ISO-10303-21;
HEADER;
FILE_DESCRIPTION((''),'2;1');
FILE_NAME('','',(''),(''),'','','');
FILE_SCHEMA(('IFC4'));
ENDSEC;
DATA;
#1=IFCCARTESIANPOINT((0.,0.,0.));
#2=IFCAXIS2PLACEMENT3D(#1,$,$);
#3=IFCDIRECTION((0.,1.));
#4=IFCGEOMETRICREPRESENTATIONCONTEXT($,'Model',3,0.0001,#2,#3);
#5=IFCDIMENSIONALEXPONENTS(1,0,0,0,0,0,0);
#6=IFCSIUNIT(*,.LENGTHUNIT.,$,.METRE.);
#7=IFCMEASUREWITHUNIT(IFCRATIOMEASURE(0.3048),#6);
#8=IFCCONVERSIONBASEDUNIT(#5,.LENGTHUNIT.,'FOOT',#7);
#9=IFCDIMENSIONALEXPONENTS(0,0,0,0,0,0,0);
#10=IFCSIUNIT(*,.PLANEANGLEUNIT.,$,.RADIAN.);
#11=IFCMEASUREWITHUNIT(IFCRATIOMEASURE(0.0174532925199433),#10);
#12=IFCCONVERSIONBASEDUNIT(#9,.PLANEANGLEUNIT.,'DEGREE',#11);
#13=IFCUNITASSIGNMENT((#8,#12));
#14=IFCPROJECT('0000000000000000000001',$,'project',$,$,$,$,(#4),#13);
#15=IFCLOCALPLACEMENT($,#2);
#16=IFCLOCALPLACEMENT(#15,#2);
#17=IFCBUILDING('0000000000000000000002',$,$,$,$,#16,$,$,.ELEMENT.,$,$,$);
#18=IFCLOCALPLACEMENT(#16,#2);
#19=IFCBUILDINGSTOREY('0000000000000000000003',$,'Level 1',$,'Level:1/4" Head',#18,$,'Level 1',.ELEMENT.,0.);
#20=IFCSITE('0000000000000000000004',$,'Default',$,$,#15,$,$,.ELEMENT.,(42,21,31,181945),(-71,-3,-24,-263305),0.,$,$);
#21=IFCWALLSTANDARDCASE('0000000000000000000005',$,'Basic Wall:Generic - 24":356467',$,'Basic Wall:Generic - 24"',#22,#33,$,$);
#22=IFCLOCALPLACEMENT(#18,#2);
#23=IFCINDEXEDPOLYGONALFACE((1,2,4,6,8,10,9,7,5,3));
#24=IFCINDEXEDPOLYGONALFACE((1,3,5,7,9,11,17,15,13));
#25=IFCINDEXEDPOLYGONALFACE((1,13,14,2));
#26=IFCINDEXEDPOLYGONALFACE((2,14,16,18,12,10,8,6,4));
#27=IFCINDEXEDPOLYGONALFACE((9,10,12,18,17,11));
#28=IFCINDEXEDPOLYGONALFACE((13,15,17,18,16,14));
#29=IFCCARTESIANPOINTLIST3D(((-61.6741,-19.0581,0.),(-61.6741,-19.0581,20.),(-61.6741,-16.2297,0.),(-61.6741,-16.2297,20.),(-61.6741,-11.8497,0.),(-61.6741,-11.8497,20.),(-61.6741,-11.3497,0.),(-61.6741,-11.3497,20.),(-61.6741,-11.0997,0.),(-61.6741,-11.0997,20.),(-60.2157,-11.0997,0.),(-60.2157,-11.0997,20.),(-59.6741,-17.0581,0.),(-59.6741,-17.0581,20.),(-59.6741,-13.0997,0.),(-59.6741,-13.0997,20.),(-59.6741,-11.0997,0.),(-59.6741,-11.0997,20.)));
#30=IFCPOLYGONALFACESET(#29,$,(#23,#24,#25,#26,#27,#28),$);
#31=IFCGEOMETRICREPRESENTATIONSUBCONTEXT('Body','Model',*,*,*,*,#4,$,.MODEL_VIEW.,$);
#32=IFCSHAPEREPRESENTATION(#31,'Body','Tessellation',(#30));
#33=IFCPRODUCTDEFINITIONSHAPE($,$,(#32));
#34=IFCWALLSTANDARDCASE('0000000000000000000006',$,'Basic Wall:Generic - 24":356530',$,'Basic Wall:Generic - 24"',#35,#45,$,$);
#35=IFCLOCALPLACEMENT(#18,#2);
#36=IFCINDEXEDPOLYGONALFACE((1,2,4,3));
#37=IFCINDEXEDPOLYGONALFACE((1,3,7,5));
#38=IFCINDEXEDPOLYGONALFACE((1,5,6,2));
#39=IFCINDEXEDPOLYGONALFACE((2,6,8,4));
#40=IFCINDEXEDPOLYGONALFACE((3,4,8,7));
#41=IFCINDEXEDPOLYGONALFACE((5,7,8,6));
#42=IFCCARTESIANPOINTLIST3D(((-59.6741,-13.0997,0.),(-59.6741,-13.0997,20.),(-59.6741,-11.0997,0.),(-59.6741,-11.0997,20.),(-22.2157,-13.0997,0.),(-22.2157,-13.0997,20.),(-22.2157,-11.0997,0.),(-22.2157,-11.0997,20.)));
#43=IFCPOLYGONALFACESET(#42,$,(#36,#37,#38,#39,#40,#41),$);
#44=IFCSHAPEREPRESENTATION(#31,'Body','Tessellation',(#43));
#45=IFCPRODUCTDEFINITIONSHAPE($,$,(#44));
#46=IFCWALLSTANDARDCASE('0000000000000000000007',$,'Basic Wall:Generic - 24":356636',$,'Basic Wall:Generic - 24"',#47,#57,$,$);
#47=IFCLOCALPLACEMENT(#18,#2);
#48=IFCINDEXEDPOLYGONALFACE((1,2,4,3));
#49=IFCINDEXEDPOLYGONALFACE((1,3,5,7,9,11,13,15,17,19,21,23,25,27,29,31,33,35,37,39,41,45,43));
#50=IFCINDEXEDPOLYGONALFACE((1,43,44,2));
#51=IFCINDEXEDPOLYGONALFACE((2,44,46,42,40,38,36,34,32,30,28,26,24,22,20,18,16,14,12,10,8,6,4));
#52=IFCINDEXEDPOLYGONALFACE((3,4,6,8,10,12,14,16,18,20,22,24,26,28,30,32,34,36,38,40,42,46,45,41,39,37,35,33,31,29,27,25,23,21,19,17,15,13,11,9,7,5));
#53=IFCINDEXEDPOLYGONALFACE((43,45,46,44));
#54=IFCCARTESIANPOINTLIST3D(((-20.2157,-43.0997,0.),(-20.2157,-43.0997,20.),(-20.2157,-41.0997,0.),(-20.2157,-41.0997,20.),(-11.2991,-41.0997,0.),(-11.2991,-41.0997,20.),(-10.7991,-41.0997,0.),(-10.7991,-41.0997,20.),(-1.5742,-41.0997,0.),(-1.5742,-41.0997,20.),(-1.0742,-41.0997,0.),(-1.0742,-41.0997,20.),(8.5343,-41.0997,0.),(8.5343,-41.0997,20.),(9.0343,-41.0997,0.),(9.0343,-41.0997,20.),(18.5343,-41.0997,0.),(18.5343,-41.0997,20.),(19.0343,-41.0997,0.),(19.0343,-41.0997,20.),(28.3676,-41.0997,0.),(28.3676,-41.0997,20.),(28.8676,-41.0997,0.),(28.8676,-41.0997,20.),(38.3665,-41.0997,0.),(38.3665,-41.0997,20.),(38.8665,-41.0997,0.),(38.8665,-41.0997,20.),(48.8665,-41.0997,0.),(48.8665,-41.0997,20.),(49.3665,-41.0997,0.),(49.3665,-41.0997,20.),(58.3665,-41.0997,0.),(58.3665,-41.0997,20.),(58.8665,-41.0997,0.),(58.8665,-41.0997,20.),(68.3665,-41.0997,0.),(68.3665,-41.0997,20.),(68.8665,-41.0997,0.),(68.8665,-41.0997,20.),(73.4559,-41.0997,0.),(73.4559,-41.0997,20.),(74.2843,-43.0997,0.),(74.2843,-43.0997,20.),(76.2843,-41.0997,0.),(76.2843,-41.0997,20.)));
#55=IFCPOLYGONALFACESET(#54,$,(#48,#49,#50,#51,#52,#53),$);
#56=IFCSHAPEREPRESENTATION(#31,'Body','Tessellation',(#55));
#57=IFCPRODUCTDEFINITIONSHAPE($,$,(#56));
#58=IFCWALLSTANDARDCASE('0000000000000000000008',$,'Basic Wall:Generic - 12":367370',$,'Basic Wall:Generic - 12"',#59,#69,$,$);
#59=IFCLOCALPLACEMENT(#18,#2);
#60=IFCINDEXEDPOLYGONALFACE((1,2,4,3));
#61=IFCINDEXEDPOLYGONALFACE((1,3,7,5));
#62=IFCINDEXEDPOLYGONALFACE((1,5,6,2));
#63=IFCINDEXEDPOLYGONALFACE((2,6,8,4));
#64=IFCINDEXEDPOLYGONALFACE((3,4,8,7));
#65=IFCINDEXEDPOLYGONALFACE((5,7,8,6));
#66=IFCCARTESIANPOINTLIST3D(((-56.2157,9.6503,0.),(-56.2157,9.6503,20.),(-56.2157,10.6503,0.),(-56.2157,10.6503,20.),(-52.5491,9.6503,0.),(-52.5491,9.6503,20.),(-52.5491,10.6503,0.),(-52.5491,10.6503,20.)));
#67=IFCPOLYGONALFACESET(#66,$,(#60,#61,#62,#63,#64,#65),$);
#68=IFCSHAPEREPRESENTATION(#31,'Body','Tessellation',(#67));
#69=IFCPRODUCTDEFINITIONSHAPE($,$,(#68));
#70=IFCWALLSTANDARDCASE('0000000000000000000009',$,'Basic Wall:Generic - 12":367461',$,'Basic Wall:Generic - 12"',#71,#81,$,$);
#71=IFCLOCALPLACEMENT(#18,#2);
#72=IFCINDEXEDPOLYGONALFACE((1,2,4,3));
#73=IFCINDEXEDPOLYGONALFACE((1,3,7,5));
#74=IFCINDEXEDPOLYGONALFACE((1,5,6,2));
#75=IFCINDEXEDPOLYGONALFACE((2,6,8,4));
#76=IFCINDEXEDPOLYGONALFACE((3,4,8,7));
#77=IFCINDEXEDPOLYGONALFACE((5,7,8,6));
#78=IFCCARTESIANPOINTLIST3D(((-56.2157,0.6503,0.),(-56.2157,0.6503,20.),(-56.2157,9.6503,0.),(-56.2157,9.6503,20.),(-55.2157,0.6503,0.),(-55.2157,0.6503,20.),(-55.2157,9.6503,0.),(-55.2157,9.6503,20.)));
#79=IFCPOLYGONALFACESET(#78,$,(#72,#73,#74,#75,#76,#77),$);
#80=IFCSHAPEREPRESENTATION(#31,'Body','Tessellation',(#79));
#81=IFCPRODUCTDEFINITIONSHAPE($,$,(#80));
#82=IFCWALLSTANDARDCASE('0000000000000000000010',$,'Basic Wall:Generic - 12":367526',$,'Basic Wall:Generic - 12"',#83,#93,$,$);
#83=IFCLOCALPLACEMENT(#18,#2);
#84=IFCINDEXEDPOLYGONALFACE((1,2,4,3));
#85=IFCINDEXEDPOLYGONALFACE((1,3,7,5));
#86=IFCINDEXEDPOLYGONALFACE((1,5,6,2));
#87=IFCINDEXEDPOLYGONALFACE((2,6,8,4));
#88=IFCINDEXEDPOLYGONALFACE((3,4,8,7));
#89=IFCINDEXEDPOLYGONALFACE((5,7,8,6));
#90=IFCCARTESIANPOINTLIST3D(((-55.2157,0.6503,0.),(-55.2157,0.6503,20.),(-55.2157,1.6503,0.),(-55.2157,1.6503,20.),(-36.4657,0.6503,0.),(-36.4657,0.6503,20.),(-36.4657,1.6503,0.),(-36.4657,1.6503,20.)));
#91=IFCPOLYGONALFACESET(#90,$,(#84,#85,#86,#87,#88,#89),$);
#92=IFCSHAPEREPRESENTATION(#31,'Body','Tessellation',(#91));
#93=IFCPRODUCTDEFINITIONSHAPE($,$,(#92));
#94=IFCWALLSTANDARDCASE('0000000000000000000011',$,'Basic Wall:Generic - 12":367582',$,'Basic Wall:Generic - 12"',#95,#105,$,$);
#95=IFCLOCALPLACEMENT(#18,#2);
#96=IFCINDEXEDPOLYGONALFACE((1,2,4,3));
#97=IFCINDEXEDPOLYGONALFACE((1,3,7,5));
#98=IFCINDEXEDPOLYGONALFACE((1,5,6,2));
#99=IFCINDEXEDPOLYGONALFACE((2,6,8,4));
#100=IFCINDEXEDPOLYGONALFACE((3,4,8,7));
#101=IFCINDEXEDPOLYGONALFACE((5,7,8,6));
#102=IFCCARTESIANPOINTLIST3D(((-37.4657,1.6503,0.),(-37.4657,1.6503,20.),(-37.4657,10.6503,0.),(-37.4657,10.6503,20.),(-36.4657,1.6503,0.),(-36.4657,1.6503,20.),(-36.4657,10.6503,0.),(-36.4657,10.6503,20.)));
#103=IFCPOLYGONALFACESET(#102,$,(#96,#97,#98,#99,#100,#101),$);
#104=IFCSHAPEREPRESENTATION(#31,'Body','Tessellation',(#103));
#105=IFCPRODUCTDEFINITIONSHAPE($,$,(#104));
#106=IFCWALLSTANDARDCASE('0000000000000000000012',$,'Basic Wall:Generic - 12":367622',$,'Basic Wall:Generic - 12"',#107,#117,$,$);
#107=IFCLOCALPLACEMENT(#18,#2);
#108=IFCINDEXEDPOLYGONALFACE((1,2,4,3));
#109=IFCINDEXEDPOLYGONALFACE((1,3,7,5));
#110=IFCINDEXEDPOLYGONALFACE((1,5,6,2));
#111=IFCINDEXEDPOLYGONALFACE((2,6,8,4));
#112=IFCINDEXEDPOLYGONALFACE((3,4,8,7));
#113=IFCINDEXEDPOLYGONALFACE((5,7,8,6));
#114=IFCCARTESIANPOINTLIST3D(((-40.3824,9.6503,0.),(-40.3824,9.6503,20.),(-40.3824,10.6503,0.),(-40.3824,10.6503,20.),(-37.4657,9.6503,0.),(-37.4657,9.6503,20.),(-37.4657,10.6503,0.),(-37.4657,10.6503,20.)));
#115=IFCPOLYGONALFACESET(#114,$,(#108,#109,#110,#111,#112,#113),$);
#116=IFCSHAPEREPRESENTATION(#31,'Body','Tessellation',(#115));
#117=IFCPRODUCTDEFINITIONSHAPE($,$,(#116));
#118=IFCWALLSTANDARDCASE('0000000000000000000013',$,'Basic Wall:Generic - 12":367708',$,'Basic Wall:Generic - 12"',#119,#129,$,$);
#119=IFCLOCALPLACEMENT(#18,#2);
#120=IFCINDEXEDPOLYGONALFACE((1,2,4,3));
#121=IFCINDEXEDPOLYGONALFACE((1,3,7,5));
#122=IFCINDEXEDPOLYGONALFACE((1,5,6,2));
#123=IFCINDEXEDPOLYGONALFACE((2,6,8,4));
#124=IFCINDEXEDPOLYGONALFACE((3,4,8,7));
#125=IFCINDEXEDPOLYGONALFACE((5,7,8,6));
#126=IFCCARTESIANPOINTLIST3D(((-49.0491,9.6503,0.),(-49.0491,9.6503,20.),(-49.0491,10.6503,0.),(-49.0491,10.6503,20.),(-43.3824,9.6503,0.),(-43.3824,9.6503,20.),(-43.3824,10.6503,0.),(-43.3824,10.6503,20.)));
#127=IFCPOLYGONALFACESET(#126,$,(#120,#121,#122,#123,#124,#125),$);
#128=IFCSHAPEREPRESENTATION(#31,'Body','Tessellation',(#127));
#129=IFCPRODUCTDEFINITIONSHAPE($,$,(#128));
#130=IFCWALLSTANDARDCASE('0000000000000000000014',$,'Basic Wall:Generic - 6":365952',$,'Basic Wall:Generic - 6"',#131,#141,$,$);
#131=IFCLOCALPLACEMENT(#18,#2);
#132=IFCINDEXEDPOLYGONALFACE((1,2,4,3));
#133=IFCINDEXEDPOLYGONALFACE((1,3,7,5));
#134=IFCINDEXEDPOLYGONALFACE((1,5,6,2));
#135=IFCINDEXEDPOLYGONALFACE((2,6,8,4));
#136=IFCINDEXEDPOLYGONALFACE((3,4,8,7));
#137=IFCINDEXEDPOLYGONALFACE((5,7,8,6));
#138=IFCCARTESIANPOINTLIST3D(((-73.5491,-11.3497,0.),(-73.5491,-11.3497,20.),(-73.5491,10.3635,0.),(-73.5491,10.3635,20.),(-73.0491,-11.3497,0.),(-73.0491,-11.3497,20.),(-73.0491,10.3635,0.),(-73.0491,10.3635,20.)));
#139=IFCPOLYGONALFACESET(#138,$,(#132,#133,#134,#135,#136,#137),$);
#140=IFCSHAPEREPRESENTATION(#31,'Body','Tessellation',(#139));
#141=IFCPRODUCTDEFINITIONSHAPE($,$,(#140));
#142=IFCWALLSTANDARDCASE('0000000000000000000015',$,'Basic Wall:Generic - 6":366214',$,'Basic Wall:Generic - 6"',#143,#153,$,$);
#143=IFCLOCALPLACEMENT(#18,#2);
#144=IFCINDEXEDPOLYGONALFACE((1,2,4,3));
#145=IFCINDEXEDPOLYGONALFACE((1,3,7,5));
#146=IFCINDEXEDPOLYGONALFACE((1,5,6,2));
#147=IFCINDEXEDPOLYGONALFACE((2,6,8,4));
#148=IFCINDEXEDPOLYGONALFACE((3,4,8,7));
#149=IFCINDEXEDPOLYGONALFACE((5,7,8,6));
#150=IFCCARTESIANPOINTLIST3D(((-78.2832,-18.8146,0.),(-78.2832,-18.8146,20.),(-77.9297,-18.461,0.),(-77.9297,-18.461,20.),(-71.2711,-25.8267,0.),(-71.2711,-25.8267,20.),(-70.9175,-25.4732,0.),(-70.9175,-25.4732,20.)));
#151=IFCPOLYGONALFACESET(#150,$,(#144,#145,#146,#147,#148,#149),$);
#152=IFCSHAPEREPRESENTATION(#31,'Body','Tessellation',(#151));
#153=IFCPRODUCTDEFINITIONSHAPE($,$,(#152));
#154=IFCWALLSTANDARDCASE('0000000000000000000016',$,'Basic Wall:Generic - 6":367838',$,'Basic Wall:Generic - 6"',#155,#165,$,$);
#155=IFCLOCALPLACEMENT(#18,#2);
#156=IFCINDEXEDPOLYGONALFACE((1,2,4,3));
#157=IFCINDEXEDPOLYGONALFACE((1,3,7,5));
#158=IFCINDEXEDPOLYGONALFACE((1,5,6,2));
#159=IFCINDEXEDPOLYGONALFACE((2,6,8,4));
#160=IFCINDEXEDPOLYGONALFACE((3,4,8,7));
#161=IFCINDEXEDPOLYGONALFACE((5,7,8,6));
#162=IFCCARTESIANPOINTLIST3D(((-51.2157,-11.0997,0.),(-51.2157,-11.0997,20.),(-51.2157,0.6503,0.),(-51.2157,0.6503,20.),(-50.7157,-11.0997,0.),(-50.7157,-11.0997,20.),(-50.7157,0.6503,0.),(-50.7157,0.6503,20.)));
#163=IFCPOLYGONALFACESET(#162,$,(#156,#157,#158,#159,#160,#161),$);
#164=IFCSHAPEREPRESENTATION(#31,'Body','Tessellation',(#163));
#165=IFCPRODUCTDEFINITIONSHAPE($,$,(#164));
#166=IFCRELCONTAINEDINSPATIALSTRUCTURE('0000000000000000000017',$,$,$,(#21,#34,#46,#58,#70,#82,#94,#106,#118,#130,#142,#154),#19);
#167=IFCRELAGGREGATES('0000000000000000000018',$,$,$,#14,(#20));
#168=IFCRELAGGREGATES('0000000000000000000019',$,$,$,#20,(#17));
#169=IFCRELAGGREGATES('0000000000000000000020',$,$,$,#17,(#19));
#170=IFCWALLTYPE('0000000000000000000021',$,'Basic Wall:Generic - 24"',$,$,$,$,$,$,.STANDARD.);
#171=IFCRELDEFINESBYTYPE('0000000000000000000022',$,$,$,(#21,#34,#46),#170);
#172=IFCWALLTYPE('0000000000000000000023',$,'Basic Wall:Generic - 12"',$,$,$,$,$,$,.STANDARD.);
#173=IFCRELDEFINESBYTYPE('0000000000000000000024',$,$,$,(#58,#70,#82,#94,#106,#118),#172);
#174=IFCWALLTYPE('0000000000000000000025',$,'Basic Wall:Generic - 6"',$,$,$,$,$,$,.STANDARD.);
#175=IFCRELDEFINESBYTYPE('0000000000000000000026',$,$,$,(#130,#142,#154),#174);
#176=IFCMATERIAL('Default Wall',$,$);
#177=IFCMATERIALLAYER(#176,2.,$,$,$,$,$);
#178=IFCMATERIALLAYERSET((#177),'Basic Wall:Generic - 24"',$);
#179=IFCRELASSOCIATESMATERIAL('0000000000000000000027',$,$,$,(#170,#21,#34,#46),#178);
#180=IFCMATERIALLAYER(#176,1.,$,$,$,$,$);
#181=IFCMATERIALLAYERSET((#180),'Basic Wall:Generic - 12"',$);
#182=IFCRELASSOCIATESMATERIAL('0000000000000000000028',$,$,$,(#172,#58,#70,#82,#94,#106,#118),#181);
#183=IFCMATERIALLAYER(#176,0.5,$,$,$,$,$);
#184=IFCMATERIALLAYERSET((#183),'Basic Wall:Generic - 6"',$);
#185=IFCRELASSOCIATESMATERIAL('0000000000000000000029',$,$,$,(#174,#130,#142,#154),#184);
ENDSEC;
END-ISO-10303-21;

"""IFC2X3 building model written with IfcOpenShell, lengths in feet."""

from ifc_helpers import new_model, entity, si_unit, converted_unit, direction, frame, frame_2d, origin, place, context, subcontext, project, spatial, polyline, rectangle, outline, extrude, material, layer, layer_set, layer_usage, type_object, element, save


model = new_model("IFC2X3")

# Units and contexts
model_context = context("Model", 3, precision=0.0001, world=origin(), true_north=direction((0.0, 1.0)))
body_context = subcontext(model_context, "Body", "Model", "MODEL_VIEW")
ifc_project = project(units=[converted_unit("LENGTHUNIT", "FOOT", entity("IfcRatioMeasure", 0.3048), si_unit("LENGTHUNIT", "METRE"), dimensions=[1, 0, 0, 0, 0, 0, 0]), converted_unit("PLANEANGLEUNIT", "DEGREE", entity("IfcRatioMeasure", 0.0174532925199433), si_unit("PLANEANGLEUNIT", "RADIAN"), dimensions=[0, 0, 0, 0, 0, 0, 0])], contexts=[model_context])

# Site, building, storey
site_placement = place(None, origin())
site = spatial("IfcSite", under=ifc_project, at=site_placement, Name="Default", CompositionType="ELEMENT", RefLatitude=(42, 21, 31, 181945), RefLongitude=(-71, -3, -24, -263305), RefElevation=0.0)
building_placement = place(site_placement, origin())
building = spatial("IfcBuilding", under=site, at=building_placement, CompositionType="ELEMENT")
storey_placement = place(building_placement, origin())
storey = spatial("IfcBuildingStorey", under=building, at=storey_placement, Name="Level 1", ObjectType="Level:1/4\" Head", LongName="Level 1", CompositionType="ELEMENT", Elevation=0.0)

# Walls
ifc_material = material(Name="Default Wall")
ifc_layer_1 = layer(ifc_material, 2.0)
ifc_layer_set_1 = layer_set([ifc_layer_1], Name="Basic Wall:Generic - 24\"")
ifc_layer_usage_1 = layer_usage(ifc_layer_set_1, "AXIS2", "NEGATIVE", 1.0)
wall_type_1 = type_object("IfcWallType", Name="Basic Wall:Generic - 24\"", PredefinedType="STANDARD", material=ifc_layer_set_1)
wall_1_placement = place(storey_placement, frame((-60.6741, -19.0581, 0.0), z_axis=(0.0, 0.0, 1.0), x_axis=(0.0, 1.0, 0.0)))
element("IfcWallStandardCase", 1, at=wall_1_placement, inside=storey, type_object=wall_type_1, material=ifc_layer_usage_1, Name="Basic Wall:Generic - 24\":356467", ObjectType="Basic Wall:Generic - 24\"", context=body_context, shape_type="SweptSolid", body=[
    extrude(outline(polyline([(7.9584, -1.0), (7.9584, -0.4583), (7.9584, 1.0), (7.7084, 1.0), (7.2084, 1.0), (2.8284, 1.0), (0.0, 1.0), (2.0, -1.0), (5.9584, -1.0), (7.9584, -1.0)])), origin(), (0.0, 0.0, 1.0), 20.0),
])
ifc_layer_usage_2 = layer_usage(ifc_layer_set_1, "AXIS2", "NEGATIVE", 1.0)
wall_2_placement = place(storey_placement, frame((-59.6741, -12.0997, 0.0)))
element("IfcWallStandardCase", 2, at=wall_2_placement, inside=storey, type_object=wall_type_1, material=ifc_layer_usage_2, Name="Basic Wall:Generic - 24\":356530", ObjectType="Basic Wall:Generic - 24\"", context=body_context, shape_type="SweptSolid", body=[
    extrude(rectangle(XDim=37.4583, YDim=2.0, at=frame_2d((18.7292, 0.0), x_axis=(-1.0, 0.0))), origin(), (0.0, 0.0, 1.0), 20.0),
])
ifc_layer_usage_3 = layer_usage(ifc_layer_set_1, "AXIS2", "NEGATIVE", 1.0)
wall_3_placement = place(storey_placement, frame((-20.2157, -42.0997, 0.0)))
element("IfcWallStandardCase", 3, at=wall_3_placement, inside=storey, type_object=wall_type_1, material=ifc_layer_usage_3, Name="Basic Wall:Generic - 24\":356636", ObjectType="Basic Wall:Generic - 24\"", context=body_context, shape_type="SweptSolid", body=[
    extrude(outline(polyline([(94.5, -1.0), (96.5, 1.0), (93.6716, 1.0), (89.0822, 1.0), (88.5822, 1.0), (79.0822, 1.0), (78.5822, 1.0), (69.5822, 1.0), (69.0822, 1.0), (59.0822, 1.0), (58.5822, 1.0), (49.0833, 1.0), (48.5833, 1.0), (39.25, 1.0), (38.75, 1.0), (29.25, 1.0), (28.75, 1.0), (19.1415, 1.0), (18.6415, 1.0), (9.4167, 1.0), (8.9167, 1.0), (0.0, 1.0), (0.0, -1.0), (94.5, -1.0)])), origin(), (0.0, 0.0, 1.0), 20.0),
])
ifc_layer_2 = layer(ifc_material, 1.0)
ifc_layer_set_2 = layer_set([ifc_layer_2], Name="Basic Wall:Generic - 12\"")
ifc_layer_usage_4 = layer_usage(ifc_layer_set_2, "AXIS2", "NEGATIVE", 0.5)
wall_type_2 = type_object("IfcWallType", Name="Basic Wall:Generic - 12\"", PredefinedType="STANDARD", material=ifc_layer_set_2)
wall_4_placement = place(storey_placement, frame((-52.5491, 10.1503, 0.0), z_axis=(0.0, 0.0, 1.0), x_axis=(-1.0, 0.0, 0.0)))
element("IfcWallStandardCase", 4, at=wall_4_placement, inside=storey, type_object=wall_type_2, material=ifc_layer_usage_4, Name="Basic Wall:Generic - 12\":367370", ObjectType="Basic Wall:Generic - 12\"", context=body_context, shape_type="SweptSolid", body=[
    extrude(rectangle(XDim=3.6667, YDim=1.0, at=frame_2d((1.8333, 0.0), x_axis=(-1.0, 0.0))), origin(), (0.0, 0.0, 1.0), 20.0),
])
ifc_layer_usage_5 = layer_usage(ifc_layer_set_2, "AXIS2", "NEGATIVE", 0.5)
wall_5_placement = place(storey_placement, frame((-55.7157, 9.6503, 0.0), z_axis=(0.0, 0.0, 1.0), x_axis=(0.0, -1.0, 0.0)))
element("IfcWallStandardCase", 5, at=wall_5_placement, inside=storey, type_object=wall_type_2, material=ifc_layer_usage_5, Name="Basic Wall:Generic - 12\":367461", ObjectType="Basic Wall:Generic - 12\"", context=body_context, shape_type="SweptSolid", body=[
    extrude(rectangle(XDim=9.0, YDim=1.0, at=frame_2d((4.5, 0.0), x_axis=(-1.0, 0.0))), origin(), (0.0, 0.0, 1.0), 20.0),
])
ifc_layer_usage_6 = layer_usage(ifc_layer_set_2, "AXIS2", "NEGATIVE", 0.5)
wall_6_placement = place(storey_placement, frame((-55.2157, 1.1503, 0.0)))
element("IfcWallStandardCase", 6, at=wall_6_placement, inside=storey, type_object=wall_type_2, material=ifc_layer_usage_6, Name="Basic Wall:Generic - 12\":367526", ObjectType="Basic Wall:Generic - 12\"", context=body_context, shape_type="SweptSolid", body=[
    extrude(rectangle(XDim=18.75, YDim=1.0, at=frame_2d((9.375, 0.0), x_axis=(-1.0, 0.0))), origin(), (0.0, 0.0, 1.0), 20.0),
])
ifc_layer_usage_7 = layer_usage(ifc_layer_set_2, "AXIS2", "NEGATIVE", 0.5)
wall_7_placement = place(storey_placement, frame((-36.9657, 1.6503, 0.0), z_axis=(0.0, 0.0, 1.0), x_axis=(0.0, 1.0, 0.0)))
element("IfcWallStandardCase", 7, at=wall_7_placement, inside=storey, type_object=wall_type_2, material=ifc_layer_usage_7, Name="Basic Wall:Generic - 12\":367582", ObjectType="Basic Wall:Generic - 12\"", context=body_context, shape_type="SweptSolid", body=[
    extrude(rectangle(XDim=9.0, YDim=1.0, at=frame_2d((4.5, 0.0), x_axis=(-1.0, 0.0))), origin(), (0.0, 0.0, 1.0), 20.0),
])
ifc_layer_usage_8 = layer_usage(ifc_layer_set_2, "AXIS2", "NEGATIVE", 0.5)
wall_8_placement = place(storey_placement, frame((-37.4657, 10.1503, 0.0), z_axis=(0.0, 0.0, 1.0), x_axis=(-1.0, 0.0, 0.0)))
element("IfcWallStandardCase", 8, at=wall_8_placement, inside=storey, type_object=wall_type_2, material=ifc_layer_usage_8, Name="Basic Wall:Generic - 12\":367622", ObjectType="Basic Wall:Generic - 12\"", context=body_context, shape_type="SweptSolid", body=[
    extrude(rectangle(XDim=2.9167, YDim=1.0, at=frame_2d((1.4583, 0.0), x_axis=(-1.0, 0.0))), origin(), (0.0, 0.0, 1.0), 20.0),
])
ifc_layer_usage_9 = layer_usage(ifc_layer_set_2, "AXIS2", "NEGATIVE", 0.5)
wall_9_placement = place(storey_placement, frame((-43.3824, 10.1503, 0.0), z_axis=(0.0, 0.0, 1.0), x_axis=(-1.0, 0.0, 0.0)))
element("IfcWallStandardCase", 9, at=wall_9_placement, inside=storey, type_object=wall_type_2, material=ifc_layer_usage_9, Name="Basic Wall:Generic - 12\":367708", ObjectType="Basic Wall:Generic - 12\"", context=body_context, shape_type="SweptSolid", body=[
    extrude(rectangle(XDim=5.6667, YDim=1.0, at=frame_2d((2.8333, 0.0), x_axis=(-1.0, 0.0))), origin(), (0.0, 0.0, 1.0), 20.0),
])
ifc_layer_3 = layer(ifc_material, 0.5)
ifc_layer_set_3 = layer_set([ifc_layer_3], Name="Basic Wall:Generic - 6\"")
ifc_layer_usage_10 = layer_usage(ifc_layer_set_3, "AXIS2", "NEGATIVE", 0.25)
wall_type_3 = type_object("IfcWallType", Name="Basic Wall:Generic - 6\"", PredefinedType="STANDARD", material=ifc_layer_set_3)
wall_10_placement = place(storey_placement, frame((-73.2991, 10.3635, 0.0), z_axis=(0.0, 0.0, 1.0), x_axis=(0.0, -1.0, 0.0)))
element("IfcWallStandardCase", 10, at=wall_10_placement, inside=storey, type_object=wall_type_3, material=ifc_layer_usage_10, Name="Basic Wall:Generic - 6\":365952", ObjectType="Basic Wall:Generic - 6\"", context=body_context, shape_type="SweptSolid", body=[
    extrude(rectangle(XDim=21.7133, YDim=0.5, at=frame_2d((10.8566, 0.0), x_axis=(-1.0, 0.0))), origin(), (0.0, 0.0, 1.0), 20.0),
])
ifc_layer_usage_11 = layer_usage(ifc_layer_set_3, "AXIS2", "NEGATIVE", 0.25)
wall_11_placement = place(storey_placement, frame((-71.0943, -25.6499, 0.0), z_axis=(0.0, 0.0, 1.0), x_axis=(-0.707107, 0.707107, 0.0)))
element("IfcWallStandardCase", 11, at=wall_11_placement, inside=storey, type_object=wall_type_3, material=ifc_layer_usage_11, Name="Basic Wall:Generic - 6\":366214", ObjectType="Basic Wall:Generic - 6\"", context=body_context, shape_type="SweptSolid", body=[
    extrude(rectangle(XDim=9.9166, YDim=0.5, at=frame_2d((4.9583, 0.0), x_axis=(-1.0, 0.0))), origin(), (0.0, 0.0, 1.0), 20.0),
])
ifc_layer_usage_12 = layer_usage(ifc_layer_set_3, "AXIS2", "NEGATIVE", 0.25)
wall_12_placement = place(storey_placement, frame((-50.9657, -11.0997, 0.0), z_axis=(0.0, 0.0, 1.0), x_axis=(0.0, 1.0, 0.0)))
element("IfcWallStandardCase", 12, at=wall_12_placement, inside=storey, type_object=wall_type_3, material=ifc_layer_usage_12, Name="Basic Wall:Generic - 6\":367838", ObjectType="Basic Wall:Generic - 6\"", context=body_context, shape_type="SweptSolid", body=[
    extrude(rectangle(XDim=11.75, YDim=0.5, at=frame_2d((5.875, 0.0), x_axis=(-1.0, 0.0))), origin(), (0.0, 0.0, 1.0), 20.0),
])

save(model, "model.ifc")
